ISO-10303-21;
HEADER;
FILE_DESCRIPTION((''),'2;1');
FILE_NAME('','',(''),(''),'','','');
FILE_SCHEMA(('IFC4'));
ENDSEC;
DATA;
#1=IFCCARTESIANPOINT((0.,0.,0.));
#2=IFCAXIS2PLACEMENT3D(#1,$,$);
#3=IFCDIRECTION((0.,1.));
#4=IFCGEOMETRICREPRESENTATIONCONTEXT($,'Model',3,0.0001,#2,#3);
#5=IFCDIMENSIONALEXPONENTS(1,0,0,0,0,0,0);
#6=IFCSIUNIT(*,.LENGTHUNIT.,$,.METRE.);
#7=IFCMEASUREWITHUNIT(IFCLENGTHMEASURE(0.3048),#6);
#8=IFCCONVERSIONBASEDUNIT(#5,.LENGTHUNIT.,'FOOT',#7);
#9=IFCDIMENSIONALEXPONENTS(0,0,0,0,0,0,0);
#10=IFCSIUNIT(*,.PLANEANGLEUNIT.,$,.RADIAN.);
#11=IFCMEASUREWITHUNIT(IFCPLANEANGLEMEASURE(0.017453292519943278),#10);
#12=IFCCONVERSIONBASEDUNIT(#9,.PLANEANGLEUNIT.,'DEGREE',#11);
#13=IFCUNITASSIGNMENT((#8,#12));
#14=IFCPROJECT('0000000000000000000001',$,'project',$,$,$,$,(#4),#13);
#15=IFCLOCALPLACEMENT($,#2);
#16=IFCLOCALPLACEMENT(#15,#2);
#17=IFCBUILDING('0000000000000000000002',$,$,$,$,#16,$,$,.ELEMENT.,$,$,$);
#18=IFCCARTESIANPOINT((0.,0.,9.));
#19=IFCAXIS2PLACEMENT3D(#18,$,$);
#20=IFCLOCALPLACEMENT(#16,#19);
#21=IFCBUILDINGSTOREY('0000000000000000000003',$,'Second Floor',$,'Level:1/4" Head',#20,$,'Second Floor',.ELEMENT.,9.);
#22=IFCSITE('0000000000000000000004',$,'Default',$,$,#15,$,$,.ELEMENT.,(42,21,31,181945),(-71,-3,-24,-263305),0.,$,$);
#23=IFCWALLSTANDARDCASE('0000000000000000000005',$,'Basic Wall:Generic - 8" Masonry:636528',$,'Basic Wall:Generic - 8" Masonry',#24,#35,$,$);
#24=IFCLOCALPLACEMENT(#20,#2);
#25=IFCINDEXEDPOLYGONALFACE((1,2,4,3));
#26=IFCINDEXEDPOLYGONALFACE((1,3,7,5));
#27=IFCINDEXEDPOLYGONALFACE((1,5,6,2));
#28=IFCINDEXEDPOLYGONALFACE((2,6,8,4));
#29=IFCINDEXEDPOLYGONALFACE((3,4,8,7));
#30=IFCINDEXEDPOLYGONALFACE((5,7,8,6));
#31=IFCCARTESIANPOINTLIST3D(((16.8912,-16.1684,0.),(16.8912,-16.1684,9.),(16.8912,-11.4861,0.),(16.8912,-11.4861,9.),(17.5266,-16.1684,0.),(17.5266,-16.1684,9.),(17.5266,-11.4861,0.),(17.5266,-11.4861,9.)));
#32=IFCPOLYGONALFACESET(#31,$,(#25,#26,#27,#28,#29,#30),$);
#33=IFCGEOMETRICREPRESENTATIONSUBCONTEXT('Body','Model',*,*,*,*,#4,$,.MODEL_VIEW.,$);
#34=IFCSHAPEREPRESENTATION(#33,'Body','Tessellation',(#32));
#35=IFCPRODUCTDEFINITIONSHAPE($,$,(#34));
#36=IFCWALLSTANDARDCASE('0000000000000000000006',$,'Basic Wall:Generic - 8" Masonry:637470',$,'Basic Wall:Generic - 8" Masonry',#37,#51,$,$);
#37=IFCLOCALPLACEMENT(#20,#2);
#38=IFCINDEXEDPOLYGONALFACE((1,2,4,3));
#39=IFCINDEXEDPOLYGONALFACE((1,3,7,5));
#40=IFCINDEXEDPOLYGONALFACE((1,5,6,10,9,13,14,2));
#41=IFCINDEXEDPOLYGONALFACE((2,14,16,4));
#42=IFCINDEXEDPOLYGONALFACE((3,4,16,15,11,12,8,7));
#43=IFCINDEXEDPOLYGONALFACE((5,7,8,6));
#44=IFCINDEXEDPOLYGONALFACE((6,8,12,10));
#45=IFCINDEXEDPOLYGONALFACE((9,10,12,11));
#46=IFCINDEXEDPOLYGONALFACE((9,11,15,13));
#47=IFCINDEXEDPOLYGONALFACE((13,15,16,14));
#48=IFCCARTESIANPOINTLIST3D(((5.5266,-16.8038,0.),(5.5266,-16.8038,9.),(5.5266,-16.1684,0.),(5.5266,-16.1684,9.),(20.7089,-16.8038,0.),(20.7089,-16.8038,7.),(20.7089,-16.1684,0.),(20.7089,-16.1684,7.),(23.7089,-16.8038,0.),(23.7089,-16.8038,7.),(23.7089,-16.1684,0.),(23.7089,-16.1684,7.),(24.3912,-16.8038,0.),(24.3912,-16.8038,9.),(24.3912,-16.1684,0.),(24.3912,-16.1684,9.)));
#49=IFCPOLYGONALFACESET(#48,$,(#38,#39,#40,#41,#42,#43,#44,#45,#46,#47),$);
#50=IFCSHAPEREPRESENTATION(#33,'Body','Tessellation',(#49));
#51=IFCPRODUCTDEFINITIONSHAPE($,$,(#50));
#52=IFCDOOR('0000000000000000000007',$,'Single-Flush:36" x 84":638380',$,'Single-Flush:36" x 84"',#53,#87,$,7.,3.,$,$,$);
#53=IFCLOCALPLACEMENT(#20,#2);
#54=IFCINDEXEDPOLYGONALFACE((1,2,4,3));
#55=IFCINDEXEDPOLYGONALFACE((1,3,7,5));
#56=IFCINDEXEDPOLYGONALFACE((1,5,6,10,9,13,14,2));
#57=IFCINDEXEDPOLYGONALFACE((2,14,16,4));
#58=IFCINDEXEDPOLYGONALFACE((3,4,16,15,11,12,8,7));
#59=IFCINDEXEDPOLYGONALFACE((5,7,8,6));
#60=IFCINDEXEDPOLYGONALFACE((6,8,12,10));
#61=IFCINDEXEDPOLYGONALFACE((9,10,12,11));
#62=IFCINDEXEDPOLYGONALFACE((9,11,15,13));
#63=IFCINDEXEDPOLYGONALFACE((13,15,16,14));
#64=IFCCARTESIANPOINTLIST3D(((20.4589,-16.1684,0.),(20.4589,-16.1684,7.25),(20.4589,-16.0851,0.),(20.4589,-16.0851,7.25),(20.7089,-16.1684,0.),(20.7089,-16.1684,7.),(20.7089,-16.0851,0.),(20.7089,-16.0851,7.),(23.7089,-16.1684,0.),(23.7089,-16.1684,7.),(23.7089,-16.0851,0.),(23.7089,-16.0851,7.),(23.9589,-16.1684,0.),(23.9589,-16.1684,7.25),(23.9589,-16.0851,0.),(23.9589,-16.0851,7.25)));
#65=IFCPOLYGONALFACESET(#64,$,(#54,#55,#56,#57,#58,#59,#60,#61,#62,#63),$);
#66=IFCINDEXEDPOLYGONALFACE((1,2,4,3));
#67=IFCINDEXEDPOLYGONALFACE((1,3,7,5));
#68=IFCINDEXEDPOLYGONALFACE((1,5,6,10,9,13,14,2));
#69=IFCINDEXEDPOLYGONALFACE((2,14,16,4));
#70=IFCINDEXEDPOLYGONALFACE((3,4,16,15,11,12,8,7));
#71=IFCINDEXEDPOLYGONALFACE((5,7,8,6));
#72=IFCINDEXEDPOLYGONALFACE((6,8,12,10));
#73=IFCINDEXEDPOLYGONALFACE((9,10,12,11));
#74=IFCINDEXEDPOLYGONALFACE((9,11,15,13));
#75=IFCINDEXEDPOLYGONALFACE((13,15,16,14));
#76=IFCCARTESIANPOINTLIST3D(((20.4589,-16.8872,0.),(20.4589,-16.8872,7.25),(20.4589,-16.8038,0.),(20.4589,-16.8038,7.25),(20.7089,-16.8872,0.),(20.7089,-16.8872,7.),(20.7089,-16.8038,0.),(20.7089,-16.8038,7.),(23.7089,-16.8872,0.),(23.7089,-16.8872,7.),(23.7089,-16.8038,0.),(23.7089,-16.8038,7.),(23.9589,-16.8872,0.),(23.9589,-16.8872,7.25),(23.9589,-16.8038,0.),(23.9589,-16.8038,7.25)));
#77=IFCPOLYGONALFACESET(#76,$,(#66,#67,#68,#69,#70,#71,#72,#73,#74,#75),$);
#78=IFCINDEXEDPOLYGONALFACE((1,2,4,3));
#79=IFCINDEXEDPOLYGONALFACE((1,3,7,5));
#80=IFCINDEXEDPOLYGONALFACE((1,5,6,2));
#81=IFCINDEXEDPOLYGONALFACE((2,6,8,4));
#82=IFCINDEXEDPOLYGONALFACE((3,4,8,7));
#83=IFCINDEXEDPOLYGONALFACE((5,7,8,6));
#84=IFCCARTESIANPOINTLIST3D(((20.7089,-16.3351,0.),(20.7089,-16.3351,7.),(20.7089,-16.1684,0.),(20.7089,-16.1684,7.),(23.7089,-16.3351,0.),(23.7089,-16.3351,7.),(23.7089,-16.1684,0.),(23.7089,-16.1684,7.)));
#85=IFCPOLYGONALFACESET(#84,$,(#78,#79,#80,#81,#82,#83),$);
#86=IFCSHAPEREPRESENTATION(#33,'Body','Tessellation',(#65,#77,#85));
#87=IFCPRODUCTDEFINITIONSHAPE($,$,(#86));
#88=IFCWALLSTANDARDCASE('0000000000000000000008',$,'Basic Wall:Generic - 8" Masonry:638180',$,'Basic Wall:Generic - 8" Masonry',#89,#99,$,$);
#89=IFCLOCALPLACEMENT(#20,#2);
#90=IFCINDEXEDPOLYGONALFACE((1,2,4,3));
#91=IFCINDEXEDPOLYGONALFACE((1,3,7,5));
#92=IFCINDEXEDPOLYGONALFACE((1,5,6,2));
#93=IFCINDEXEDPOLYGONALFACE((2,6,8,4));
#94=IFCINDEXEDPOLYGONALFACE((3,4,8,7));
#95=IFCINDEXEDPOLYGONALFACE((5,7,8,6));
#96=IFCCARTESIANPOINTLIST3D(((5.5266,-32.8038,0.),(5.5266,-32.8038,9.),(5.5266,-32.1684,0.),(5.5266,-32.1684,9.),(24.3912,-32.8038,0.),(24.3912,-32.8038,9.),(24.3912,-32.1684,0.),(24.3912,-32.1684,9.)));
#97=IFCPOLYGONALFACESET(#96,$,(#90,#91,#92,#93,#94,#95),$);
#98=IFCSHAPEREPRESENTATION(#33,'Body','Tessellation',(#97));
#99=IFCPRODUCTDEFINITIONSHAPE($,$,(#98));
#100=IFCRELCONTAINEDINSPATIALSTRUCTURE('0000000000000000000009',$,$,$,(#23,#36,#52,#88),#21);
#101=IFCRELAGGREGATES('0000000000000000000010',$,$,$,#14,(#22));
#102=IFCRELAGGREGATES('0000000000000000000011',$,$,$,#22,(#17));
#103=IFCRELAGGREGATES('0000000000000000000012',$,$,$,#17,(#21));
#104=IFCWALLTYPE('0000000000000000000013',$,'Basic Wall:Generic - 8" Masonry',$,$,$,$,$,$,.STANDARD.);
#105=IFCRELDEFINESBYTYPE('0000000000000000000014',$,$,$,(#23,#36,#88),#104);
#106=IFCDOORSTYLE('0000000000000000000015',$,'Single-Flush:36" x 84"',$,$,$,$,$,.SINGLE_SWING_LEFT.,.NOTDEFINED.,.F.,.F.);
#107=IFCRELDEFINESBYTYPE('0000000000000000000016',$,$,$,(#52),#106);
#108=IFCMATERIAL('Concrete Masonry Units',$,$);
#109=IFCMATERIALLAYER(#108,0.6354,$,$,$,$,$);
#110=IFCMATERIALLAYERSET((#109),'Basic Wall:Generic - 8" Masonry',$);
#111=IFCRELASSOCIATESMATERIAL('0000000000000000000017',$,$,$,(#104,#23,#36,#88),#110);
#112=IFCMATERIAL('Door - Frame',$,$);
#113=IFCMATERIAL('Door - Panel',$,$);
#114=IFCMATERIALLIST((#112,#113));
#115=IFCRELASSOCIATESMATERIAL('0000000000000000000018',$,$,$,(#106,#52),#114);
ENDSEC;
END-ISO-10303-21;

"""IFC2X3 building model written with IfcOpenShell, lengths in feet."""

from ifc_helpers import new_model, entity, si_unit, converted_unit, direction, frame, frame_2d, origin, place, context, subcontext, project, spatial, polyline, rectangle, outline, extrude, source, transform, mapped, material, material_list, layer, layer_set, layer_usage, type_object, type_shapes, element, fill, save


model = new_model("IFC2X3")

# Units and contexts
model_context = context("Model", 3, precision=0.0001, world=origin(), true_north=direction((0.0, 1.0)))
body_context = subcontext(model_context, "Body", "Model", "MODEL_VIEW")
ifc_project = project(units=[converted_unit("LENGTHUNIT", "FOOT", entity("IfcLengthMeasure", 0.3048), si_unit("LENGTHUNIT", "METRE"), dimensions=[1, 0, 0, 0, 0, 0, 0]), converted_unit("PLANEANGLEUNIT", "DEGREE", entity("IfcPlaneAngleMeasure", 0.017453292519943278), si_unit("PLANEANGLEUNIT", "RADIAN"), dimensions=[0, 0, 0, 0, 0, 0, 0])], contexts=[model_context])

# Site, building, storey
site_placement = place(None, origin())
site = spatial("IfcSite", under=ifc_project, at=site_placement, Name="Default", CompositionType="ELEMENT", RefLatitude=(42, 21, 31, 181945), RefLongitude=(-71, -3, -24, -263305), RefElevation=0.0)
building_placement = place(site_placement, origin())
building = spatial("IfcBuilding", under=site, at=building_placement, CompositionType="ELEMENT")
storey_placement = place(building_placement, frame((0.0, 0.0, 9.0)))
storey = spatial("IfcBuildingStorey", under=building, at=storey_placement, Name="Second Floor", ObjectType="Level:1/4\" Head", LongName="Second Floor", CompositionType="ELEMENT", Elevation=9.0)

# Wall
ifc_material_1 = material(Name="Concrete Masonry Units")
ifc_layer = layer(ifc_material_1, 0.6354)
ifc_layer_set = layer_set([ifc_layer], Name="Basic Wall:Generic - 8\" Masonry")
ifc_layer_usage_1 = layer_usage(ifc_layer_set, "AXIS2", "NEGATIVE", 0.3177)
wall_type = type_object("IfcWallType", Name="Basic Wall:Generic - 8\" Masonry", PredefinedType="STANDARD", material=ifc_layer_set)
wall_1_placement = place(storey_placement, frame((17.2089, -16.1684, 0.0), z_axis=(0.0, 0.0, 1.0), x_axis=(0.0, 1.0, 0.0)))
element("IfcWallStandardCase", 1, at=wall_1_placement, inside=storey, type_object=wall_type, material=ifc_layer_usage_1, Name="Basic Wall:Generic - 8\" Masonry:636528", ObjectType="Basic Wall:Generic - 8\" Masonry", context=body_context, shape_type="SweptSolid", body=[
    extrude(rectangle(XDim=4.6823, YDim=0.6354, at=frame_2d((2.3411, 0.0), x_axis=(-1.0, 0.0))), origin(), (0.0, 0.0, 1.0), 9.0),
])

# Wall, opening, door
ifc_layer_usage_2 = layer_usage(ifc_layer_set, "AXIS2", "NEGATIVE", 0.3177)
wall_2_placement = place(storey_placement, frame((5.5266, -16.4861, 0.0)))
wall_2 = element("IfcWallStandardCase", 2, at=wall_2_placement, inside=storey, type_object=wall_type, material=ifc_layer_usage_2, Name="Basic Wall:Generic - 8\" Masonry:637470", ObjectType="Basic Wall:Generic - 8\" Masonry", context=body_context, shape_type="SweptSolid", body=[
    extrude(rectangle(XDim=18.8646, YDim=0.6354, at=frame_2d((9.4323, 0.0), x_axis=(1.0, 0.0))), origin(), (0.0, 0.0, 1.0), 9.0),
])
opening_1_placement = place(wall_2_placement, frame((15.1823, -0.3177, 0.0)))
opening_1 = element("IfcOpeningElement", 3, at=opening_1_placement, cuts=wall_2, ObjectType="Opening", context=body_context, shape_type="SweptSolid", body=[
    extrude(rectangle(XDim=3.0, YDim=7.0, at=frame_2d((3.5, 1.5), x_axis=(0.0, -1.0))), frame((0.0, 0.0, 0.0), z_axis=(0.0, 1.0, 0.0), x_axis=(0.0, 0.0, 1.0)), (0.0, 0.0, 1.0), 0.6354),
])
ifc_material_2 = material(Name="Door - Frame")
ifc_material_3 = material(Name="Door - Panel")
ifc_material_list_1 = material_list([ifc_material_2, ifc_material_3])
door_style_1 = type_object("IfcDoorStyle", Name="Single-Flush:36\" x 84\"", ConstructionType="NOTDEFINED", OperationType="SINGLE_SWING_LEFT", ParameterTakesPrecedence=False, Sizeable=False, material=ifc_material_list_1)
shared_shape_1 = source(origin(), body_context, "Body", "SweptSolid", [
    extrude(outline(polyline([(-1.75, -3.6875), (1.75, -3.6875), (1.75, 3.5625), (1.5, 3.5625), (1.5, -3.4375), (-1.5, -3.4375), (-1.5, 3.5625), (-1.75, 3.5625), (-1.75, -3.6875)])), frame((1.5, 0.7187, 3.5625), z_axis=(0.0, -1.0, 0.0), x_axis=(-1.0, 0.0, 0.0)), (0.0, 0.0, 1.0), 0.0833),
    extrude(outline(polyline([(-3.6875, -1.75), (3.5625, -1.75), (3.5625, -1.5), (-3.4375, -1.5), (-3.4375, 1.5), (3.5625, 1.5), (3.5625, 1.75), (-3.6875, 1.75), (-3.6875, -1.75)])), frame((1.5, 0.0, 3.5625), z_axis=(0.0, -1.0, 0.0), x_axis=(0.0, 0.0, -1.0)), (0.0, 0.0, 1.0), 0.0833),
    extrude(rectangle(XDim=3.0, YDim=0.1667, at=frame_2d((0.0, 0.0), x_axis=(1.0, 0.0))), frame((1.5, 0.5521, 0.0)), (0.0, 0.0, 1.0), 7.0),
])
type_shapes(door_style_1, [shared_shape_1])
door_1_placement = place(opening_1_placement, origin())
door_1 = element("IfcDoor", 4, at=door_1_placement, inside=storey, type_object=door_style_1, material=ifc_material_list_1, Name="Single-Flush:36\" x 84\":638380", ObjectType="Single-Flush:36\" x 84\"", OverallHeight=7.0, OverallWidth=3.0, context=body_context, shape_type="MappedRepresentation", body=[
    mapped(shared_shape_1, transform((0.0, 0.0, 0.0), scale=1.0)),
])
fill(opening_1, door_1)

# Wall
ifc_layer_usage_3 = layer_usage(ifc_layer_set, "AXIS2", "NEGATIVE", 0.3177)
wall_3_placement = place(storey_placement, frame((5.5266, -32.4861, 0.0)))
element("IfcWallStandardCase", 5, at=wall_3_placement, inside=storey, type_object=wall_type, material=ifc_layer_usage_3, Name="Basic Wall:Generic - 8\" Masonry:638180", ObjectType="Basic Wall:Generic - 8\" Masonry", context=body_context, shape_type="SweptSolid", body=[
    extrude(rectangle(XDim=18.8646, YDim=0.6354, at=frame_2d((9.4323, 0.0), x_axis=(-1.0, 0.0))), origin(), (0.0, 0.0, 1.0), 9.0),
])

save(model, "model.ifc")
